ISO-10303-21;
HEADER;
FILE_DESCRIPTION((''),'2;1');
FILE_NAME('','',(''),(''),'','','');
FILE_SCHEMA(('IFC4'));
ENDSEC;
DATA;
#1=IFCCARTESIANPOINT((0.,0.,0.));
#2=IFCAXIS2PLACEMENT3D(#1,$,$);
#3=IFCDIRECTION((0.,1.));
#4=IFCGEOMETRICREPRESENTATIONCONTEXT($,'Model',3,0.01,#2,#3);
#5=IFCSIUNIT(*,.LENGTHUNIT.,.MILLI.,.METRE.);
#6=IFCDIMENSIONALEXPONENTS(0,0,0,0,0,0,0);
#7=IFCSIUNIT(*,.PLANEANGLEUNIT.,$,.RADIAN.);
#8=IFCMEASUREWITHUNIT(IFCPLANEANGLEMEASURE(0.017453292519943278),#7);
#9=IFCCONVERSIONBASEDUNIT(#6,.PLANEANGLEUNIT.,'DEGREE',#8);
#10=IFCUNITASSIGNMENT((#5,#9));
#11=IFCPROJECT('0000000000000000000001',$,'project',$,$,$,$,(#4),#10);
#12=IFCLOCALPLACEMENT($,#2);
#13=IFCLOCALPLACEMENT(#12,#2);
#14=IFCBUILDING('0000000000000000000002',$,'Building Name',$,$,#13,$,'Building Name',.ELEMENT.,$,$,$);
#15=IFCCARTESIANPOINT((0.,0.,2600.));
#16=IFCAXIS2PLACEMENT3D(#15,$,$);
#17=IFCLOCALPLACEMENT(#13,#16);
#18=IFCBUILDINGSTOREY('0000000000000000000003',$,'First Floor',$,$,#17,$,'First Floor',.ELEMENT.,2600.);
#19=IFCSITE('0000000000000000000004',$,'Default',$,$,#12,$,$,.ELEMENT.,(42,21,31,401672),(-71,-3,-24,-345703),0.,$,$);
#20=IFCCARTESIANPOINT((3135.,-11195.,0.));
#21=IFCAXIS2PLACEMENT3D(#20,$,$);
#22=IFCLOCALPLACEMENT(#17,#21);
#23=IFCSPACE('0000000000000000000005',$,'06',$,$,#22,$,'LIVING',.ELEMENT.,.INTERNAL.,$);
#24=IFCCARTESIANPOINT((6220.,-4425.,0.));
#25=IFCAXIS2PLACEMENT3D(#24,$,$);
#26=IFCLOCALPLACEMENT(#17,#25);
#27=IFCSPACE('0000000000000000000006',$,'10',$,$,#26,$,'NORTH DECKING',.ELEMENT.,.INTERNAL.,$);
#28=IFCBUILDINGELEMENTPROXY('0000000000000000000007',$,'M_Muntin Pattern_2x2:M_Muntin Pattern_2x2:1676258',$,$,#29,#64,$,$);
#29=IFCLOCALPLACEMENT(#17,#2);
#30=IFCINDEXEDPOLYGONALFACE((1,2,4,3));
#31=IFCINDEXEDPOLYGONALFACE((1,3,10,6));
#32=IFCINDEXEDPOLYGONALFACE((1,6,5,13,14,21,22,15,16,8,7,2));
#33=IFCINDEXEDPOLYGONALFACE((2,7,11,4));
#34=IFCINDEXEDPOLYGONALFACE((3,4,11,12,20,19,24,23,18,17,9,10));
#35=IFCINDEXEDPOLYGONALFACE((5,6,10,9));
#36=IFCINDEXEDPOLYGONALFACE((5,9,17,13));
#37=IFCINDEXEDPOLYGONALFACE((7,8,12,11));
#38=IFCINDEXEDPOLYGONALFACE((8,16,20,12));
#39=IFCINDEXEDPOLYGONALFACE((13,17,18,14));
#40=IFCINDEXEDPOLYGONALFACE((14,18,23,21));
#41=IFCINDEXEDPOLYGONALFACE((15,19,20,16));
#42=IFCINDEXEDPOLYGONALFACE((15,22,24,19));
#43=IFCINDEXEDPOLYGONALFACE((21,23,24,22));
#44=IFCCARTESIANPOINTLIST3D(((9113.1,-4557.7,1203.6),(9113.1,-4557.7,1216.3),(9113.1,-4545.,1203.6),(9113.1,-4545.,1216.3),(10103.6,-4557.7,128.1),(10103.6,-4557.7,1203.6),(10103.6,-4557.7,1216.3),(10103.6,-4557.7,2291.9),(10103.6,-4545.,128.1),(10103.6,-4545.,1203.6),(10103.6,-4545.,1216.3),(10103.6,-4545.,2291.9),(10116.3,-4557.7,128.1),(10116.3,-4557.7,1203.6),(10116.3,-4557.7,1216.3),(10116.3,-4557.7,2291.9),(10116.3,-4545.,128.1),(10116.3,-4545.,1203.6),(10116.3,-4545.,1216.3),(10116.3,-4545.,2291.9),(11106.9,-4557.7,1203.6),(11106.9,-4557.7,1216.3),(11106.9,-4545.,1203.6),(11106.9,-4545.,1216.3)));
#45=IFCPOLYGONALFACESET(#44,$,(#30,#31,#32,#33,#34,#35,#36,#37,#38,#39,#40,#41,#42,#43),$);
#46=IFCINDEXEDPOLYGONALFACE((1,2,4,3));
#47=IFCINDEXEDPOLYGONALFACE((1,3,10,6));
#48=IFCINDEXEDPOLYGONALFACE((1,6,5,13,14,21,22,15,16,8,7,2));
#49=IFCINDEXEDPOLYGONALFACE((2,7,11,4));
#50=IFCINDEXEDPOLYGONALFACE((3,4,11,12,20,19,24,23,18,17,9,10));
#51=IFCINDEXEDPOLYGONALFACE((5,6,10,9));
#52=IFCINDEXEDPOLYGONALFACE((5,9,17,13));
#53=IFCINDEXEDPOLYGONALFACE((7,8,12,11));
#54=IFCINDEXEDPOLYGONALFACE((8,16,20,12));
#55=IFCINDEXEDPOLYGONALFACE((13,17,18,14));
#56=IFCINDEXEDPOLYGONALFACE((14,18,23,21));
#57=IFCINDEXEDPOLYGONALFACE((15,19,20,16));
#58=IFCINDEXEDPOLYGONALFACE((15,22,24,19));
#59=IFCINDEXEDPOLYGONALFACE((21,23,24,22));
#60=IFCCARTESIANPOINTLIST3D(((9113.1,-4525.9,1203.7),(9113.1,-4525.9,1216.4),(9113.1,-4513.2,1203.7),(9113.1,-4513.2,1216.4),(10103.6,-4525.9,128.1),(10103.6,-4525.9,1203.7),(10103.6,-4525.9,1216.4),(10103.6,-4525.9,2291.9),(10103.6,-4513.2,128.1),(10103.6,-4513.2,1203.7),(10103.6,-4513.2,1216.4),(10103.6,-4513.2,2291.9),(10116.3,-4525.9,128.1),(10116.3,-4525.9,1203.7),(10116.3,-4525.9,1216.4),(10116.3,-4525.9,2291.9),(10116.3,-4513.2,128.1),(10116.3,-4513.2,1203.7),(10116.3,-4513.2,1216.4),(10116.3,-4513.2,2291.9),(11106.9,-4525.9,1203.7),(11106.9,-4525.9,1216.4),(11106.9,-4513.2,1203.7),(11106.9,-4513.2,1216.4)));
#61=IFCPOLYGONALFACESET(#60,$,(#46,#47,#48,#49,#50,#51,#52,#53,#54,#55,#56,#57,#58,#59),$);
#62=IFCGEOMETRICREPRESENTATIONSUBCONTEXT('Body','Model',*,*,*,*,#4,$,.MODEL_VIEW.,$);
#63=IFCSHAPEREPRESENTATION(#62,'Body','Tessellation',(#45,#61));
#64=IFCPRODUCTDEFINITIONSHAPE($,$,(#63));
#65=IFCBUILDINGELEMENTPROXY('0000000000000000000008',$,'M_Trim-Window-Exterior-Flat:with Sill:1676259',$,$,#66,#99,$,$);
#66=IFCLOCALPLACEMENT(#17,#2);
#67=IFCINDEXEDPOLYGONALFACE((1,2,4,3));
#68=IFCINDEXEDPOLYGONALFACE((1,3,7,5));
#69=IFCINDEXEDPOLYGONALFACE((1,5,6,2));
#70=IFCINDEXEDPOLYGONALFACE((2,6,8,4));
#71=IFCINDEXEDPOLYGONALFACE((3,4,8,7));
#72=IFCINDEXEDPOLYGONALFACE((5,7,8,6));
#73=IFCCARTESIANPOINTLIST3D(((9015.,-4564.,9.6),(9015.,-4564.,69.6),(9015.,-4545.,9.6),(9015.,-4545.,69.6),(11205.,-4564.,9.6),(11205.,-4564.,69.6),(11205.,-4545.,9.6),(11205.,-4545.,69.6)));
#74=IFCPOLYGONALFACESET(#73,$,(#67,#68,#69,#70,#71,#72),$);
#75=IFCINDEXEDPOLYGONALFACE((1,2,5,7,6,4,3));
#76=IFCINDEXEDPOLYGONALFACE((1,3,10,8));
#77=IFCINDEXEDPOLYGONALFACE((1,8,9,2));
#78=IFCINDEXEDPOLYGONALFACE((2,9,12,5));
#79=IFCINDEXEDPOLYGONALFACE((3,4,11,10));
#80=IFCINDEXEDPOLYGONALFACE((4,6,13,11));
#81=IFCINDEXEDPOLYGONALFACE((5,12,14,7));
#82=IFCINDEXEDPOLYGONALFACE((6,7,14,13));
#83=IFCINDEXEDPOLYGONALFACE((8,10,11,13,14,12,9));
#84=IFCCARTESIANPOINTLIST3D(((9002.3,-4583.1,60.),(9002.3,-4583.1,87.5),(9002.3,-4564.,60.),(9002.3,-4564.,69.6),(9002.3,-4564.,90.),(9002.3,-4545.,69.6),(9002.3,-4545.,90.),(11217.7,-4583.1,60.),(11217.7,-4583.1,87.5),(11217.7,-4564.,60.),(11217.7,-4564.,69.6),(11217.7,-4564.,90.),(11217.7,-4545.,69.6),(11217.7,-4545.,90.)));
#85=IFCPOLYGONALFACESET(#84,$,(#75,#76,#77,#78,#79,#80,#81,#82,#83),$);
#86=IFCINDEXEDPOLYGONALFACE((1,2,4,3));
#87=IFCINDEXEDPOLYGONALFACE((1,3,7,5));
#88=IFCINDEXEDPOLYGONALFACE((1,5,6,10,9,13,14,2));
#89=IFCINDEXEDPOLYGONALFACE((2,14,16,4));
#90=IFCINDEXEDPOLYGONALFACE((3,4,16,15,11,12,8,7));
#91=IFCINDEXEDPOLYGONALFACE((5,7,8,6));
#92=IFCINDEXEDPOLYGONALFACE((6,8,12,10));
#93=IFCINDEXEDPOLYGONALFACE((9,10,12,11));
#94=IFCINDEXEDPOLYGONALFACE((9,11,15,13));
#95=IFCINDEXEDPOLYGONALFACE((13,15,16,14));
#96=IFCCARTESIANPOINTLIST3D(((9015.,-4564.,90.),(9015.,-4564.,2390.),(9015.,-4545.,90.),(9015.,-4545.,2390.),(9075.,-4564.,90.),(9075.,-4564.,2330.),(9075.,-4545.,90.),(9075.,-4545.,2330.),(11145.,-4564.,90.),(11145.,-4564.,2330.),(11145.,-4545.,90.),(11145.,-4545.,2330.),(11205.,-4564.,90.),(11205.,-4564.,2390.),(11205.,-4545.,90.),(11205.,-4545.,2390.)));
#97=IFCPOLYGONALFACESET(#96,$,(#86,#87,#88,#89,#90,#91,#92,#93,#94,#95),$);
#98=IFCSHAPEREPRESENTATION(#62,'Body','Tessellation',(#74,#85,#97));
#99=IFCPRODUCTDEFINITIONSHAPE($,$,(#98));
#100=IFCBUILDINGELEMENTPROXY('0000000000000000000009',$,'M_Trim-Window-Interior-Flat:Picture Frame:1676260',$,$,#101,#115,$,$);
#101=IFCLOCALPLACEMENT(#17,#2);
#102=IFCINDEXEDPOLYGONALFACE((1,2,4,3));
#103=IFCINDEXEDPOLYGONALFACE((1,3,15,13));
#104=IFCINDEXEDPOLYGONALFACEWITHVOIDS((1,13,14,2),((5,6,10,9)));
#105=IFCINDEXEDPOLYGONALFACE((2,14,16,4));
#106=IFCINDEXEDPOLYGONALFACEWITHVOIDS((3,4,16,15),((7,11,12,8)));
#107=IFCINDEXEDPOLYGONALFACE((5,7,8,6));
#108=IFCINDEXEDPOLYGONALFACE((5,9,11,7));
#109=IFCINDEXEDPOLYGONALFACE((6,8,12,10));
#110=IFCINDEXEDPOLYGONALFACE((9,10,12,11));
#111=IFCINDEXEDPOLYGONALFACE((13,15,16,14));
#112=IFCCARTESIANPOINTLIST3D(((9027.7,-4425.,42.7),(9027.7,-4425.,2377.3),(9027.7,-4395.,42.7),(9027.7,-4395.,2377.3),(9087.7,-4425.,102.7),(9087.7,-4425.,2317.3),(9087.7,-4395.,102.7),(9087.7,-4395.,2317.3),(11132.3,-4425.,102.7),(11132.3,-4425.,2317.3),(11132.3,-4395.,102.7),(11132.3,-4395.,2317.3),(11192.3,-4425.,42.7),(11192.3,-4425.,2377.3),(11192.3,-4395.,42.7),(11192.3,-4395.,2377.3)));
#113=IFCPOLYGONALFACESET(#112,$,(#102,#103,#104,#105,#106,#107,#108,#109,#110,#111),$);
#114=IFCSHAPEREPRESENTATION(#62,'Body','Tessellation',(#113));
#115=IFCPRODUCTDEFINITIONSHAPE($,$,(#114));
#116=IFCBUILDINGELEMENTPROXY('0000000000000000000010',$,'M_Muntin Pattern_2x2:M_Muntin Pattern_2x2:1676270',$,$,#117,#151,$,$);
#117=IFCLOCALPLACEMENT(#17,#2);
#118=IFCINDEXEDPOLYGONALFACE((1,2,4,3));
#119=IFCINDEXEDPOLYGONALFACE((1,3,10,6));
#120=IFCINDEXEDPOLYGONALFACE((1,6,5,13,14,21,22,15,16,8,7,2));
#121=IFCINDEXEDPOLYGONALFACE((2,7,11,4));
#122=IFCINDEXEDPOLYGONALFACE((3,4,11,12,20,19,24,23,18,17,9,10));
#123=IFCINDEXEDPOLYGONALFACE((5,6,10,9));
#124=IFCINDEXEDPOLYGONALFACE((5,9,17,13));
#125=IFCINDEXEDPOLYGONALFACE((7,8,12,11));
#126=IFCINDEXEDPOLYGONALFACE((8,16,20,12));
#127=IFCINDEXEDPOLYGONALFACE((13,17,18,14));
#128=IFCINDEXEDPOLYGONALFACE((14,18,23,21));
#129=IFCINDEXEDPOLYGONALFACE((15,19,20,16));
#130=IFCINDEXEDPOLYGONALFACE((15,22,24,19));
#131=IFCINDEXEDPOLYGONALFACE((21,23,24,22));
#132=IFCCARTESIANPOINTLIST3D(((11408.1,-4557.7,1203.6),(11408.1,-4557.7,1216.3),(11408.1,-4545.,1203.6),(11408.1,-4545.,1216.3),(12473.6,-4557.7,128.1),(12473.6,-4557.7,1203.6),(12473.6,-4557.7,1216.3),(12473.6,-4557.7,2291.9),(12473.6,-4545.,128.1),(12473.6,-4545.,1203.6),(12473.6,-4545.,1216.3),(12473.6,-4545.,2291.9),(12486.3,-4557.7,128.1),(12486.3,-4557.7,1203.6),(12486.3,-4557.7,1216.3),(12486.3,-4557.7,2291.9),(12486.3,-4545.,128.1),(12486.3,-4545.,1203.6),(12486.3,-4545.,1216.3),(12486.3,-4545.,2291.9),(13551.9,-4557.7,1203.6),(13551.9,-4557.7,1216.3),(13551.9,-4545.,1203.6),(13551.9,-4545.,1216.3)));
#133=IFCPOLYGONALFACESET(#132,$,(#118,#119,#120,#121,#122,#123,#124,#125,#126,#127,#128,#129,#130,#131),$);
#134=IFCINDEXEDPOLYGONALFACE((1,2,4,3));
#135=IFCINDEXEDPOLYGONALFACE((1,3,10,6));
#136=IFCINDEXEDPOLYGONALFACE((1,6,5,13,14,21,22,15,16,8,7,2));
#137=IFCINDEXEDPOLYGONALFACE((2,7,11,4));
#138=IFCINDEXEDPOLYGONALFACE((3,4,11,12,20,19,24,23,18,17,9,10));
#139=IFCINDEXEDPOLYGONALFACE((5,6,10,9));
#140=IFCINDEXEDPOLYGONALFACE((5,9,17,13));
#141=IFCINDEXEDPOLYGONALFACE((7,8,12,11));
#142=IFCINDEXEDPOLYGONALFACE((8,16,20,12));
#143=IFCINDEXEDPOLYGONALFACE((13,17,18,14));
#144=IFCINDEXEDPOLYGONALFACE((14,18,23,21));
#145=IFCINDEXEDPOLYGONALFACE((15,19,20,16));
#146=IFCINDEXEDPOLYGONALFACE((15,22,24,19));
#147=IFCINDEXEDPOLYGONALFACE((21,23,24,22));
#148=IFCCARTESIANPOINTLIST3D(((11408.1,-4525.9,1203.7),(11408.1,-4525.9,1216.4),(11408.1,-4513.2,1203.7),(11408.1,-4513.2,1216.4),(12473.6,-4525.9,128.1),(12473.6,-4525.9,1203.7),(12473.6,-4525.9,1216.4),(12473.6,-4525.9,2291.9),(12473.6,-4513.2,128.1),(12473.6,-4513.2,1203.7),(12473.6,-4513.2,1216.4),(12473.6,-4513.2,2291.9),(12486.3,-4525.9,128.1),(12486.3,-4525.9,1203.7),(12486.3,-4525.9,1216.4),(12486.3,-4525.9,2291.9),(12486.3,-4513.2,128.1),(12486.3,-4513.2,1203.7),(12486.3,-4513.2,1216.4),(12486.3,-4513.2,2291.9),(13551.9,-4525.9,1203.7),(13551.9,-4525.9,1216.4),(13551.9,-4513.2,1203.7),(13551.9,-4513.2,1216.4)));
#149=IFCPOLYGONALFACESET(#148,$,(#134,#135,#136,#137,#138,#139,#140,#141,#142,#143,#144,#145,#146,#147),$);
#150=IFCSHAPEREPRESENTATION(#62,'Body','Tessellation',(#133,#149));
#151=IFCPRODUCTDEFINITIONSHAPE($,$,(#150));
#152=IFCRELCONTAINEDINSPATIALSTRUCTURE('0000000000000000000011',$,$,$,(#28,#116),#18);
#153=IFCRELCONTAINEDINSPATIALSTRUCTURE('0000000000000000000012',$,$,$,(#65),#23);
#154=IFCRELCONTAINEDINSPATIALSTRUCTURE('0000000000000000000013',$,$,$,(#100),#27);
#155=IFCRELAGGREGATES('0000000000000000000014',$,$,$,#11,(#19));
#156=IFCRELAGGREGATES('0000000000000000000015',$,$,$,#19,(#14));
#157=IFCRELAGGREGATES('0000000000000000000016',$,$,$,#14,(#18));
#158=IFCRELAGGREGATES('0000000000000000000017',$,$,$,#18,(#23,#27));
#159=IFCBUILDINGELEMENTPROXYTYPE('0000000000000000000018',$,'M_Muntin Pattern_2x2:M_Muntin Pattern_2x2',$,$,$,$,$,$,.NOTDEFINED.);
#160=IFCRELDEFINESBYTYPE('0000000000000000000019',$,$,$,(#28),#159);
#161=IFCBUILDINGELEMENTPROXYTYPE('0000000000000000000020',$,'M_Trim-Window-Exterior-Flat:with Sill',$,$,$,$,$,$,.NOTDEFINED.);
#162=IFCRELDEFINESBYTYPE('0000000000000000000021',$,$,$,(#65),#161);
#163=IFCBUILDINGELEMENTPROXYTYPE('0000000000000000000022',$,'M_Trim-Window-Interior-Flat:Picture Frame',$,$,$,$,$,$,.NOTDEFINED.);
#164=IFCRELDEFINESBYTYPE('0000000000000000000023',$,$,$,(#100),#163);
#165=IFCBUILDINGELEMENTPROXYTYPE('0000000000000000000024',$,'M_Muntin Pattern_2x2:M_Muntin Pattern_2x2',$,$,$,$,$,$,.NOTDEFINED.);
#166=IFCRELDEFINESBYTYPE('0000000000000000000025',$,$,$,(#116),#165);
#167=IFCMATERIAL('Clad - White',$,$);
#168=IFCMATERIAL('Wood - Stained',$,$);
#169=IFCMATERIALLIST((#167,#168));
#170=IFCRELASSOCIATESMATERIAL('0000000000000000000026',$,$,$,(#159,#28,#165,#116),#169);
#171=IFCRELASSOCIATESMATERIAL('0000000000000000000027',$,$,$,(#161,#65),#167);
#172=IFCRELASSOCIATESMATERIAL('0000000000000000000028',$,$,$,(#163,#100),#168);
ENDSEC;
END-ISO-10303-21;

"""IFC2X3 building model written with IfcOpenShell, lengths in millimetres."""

from ifc_helpers import new_model, entity, si_unit, converted_unit, direction, frame, frame_2d, origin, place, context, subcontext, project, spatial, polyline, rectangle, outline, extrude, source, transform, mapped, material, material_list, type_object, type_shapes, element, save


model = new_model("IFC2X3")

# Units and contexts
model_context = context("Model", 3, precision=0.01, world=origin(), true_north=direction((0.0, 1.0)))
body_context = subcontext(model_context, "Body", "Model", "MODEL_VIEW")
ifc_project = project(units=[si_unit("LENGTHUNIT", "METRE", prefix="MILLI"), converted_unit("PLANEANGLEUNIT", "DEGREE", entity("IfcPlaneAngleMeasure", 0.017453292519943278), si_unit("PLANEANGLEUNIT", "RADIAN"), dimensions=[0, 0, 0, 0, 0, 0, 0])], contexts=[model_context])

# Site, building, storey
site_placement = place(None, origin())
site = spatial("IfcSite", under=ifc_project, at=site_placement, Name="Default", CompositionType="ELEMENT", RefLatitude=(42, 21, 31, 401672), RefLongitude=(-71, -3, -24, -345703), RefElevation=0.0)
building_placement = place(site_placement, origin())
building = spatial("IfcBuilding", under=site, at=building_placement, Name="Building Name", LongName="Building Name", CompositionType="ELEMENT")
storey_placement = place(building_placement, frame((0.0, 0.0, 2600.0)))
storey = spatial("IfcBuildingStorey", under=building, at=storey_placement, Name="First Floor", LongName="First Floor", CompositionType="ELEMENT", Elevation=2600.0)

# Shared definitions
space_1_placement = place(storey_placement, frame((3135.0, -11195.0, 0.0)))
space_1 = spatial("IfcSpace", under=storey, at=space_1_placement, Name="06", LongName="LIVING", CompositionType="ELEMENT", InteriorOrExteriorSpace="INTERNAL")

# Building element proxies
ifc_material_1 = material(Name="Clad - White")
ifc_material_2 = material(Name="Wood - Stained")
ifc_material_list_1 = material_list([ifc_material_1, ifc_material_2])
building_element_proxy_type_1 = type_object("IfcBuildingElementProxyType", Name="M_Muntin Pattern_2x2:M_Muntin Pattern_2x2", PredefinedType="NOTDEFINED", material=ifc_material_list_1)
shared_shape_1 = source(origin(), body_context, "Body", "SweptSolid", [
    extrude(outline(polyline([(6.4, -6.4), (1081.9, -6.4), (1081.9, 6.3), (6.4, 6.3), (6.4, 996.9), (-6.3, 996.9), (-6.3, 6.3), (-1081.9, 6.3), (-1081.9, -6.4), (-6.3, -6.4), (-6.3, -996.9), (6.4, -996.9), (6.4, -6.4)])), frame((0.0, -22.2, 1081.9), z_axis=(0.0, 1.0, 0.0), x_axis=(0.0, 0.0, 1.0)), (0.0, 0.0, 1.0), 12.7),
    extrude(outline(polyline([(6.4, -6.4), (1081.9, -6.4), (1081.9, 6.3), (6.4, 6.3), (6.4, 996.9), (-6.3, 996.9), (-6.3, 6.3), (-1081.9, 6.3), (-1081.9, -6.4), (-6.3, -6.4), (-6.3, -996.9), (6.4, -996.9), (6.4, -6.4)])), frame((0.0, 9.5, 1081.9), z_axis=(0.0, 1.0, 0.0), x_axis=(0.0, 0.0, 1.0)), (0.0, 0.0, 1.0), 12.7),
])
type_shapes(building_element_proxy_type_1, [shared_shape_1])
proxy_1_placement = place(storey_placement, frame((10110.0, -4535.5, 128.1)))
element("IfcBuildingElementProxy", 1, at=proxy_1_placement, inside=storey, type_object=building_element_proxy_type_1, material=ifc_material_list_1, Name="M_Muntin Pattern_2x2:M_Muntin Pattern_2x2:1676258", context=body_context, shape_type="MappedRepresentation", body=[
    mapped(shared_shape_1, transform((0.0, 0.0, 0.0), scale=1.0)),
])
building_element_proxy_type_2 = type_object("IfcBuildingElementProxyType", Name="M_Trim-Window-Exterior-Flat:with Sill", PredefinedType="NOTDEFINED", material=ifc_material_1)
shared_shape_2 = source(origin(), body_context, "Body", "SweptSolid", [
    extrude(rectangle(XDim=2190.0, YDim=60.0, at=frame_2d((0.0, 0.0), x_axis=(1.0, 0.0))), frame((0.0, -2290.4, 0.0), z_axis=(0.0, 0.0, 1.0), x_axis=(-1.0, 0.0, 0.0)), (0.0, 0.0, 1.0), 19.0),
    extrude(outline(polyline([(-19.0, -15.2), (0.0, -15.2), (0.0, -5.7), (19.0, -5.7), (19.0, 14.8), (0.0, 14.8), (-19.0, 12.3), (-19.0, -15.2)])), frame((-1107.7, -2254.8, 19.0), z_axis=(1.0, 0.0, 0.0), x_axis=(0.0, 0.0, -1.0)), (0.0, 0.0, 1.0), 2215.4),
    extrude(outline(polyline([(-1165.0, -1095.0), (1135.0, -1095.0), (1135.0, -1035.0), (-1105.0, -1035.0), (-1105.0, 1035.0), (1135.0, 1035.0), (1135.0, 1095.0), (-1165.0, 1095.0), (-1165.0, -1095.0)])), frame((0.0, -1105.0, 0.0), z_axis=(0.0, 0.0, 1.0), x_axis=(0.0, -1.0, 0.0)), (0.0, 0.0, 1.0), 19.0),
])
type_shapes(building_element_proxy_type_2, [shared_shape_2])
proxy_2_placement = place(space_1_placement, frame((6975.0, 6650.0, 2330.0), z_axis=(0.0, -1.0, 0.0), x_axis=(1.0, 0.0, 0.0)))
element("IfcBuildingElementProxy", 2, at=proxy_2_placement, inside=space_1, type_object=building_element_proxy_type_2, material=ifc_material_1, Name="M_Trim-Window-Exterior-Flat:with Sill:1676259", context=body_context, shape_type="MappedRepresentation", body=[
    mapped(shared_shape_2, transform((0.0, 0.0, 0.0), scale=1.0)),
])

# Shared definitions
space_2_placement = place(storey_placement, frame((6220.0, -4425.0, 0.0)))
space_2 = spatial("IfcSpace", under=storey, at=space_2_placement, Name="10", LongName="NORTH DECKING", CompositionType="ELEMENT", InteriorOrExteriorSpace="INTERNAL")

# Building element proxies
building_element_proxy_type_3 = type_object("IfcBuildingElementProxyType", Name="M_Trim-Window-Interior-Flat:Picture Frame", PredefinedType="NOTDEFINED", material=ifc_material_2)
shared_shape_3 = source(origin(), body_context, "Body", "SweptSolid", [
    extrude(outline(polyline([(-1082.3, -1167.3), (1082.3, -1167.3), (1082.3, 1167.3), (-1082.3, 1167.3), (-1082.3, -1167.3)]), holes=[polyline([(-1022.3, -1107.3), (-1022.3, 1107.3), (1022.3, 1107.3), (1022.3, -1107.3), (-1022.3, -1107.3)])]), frame((0.0, -1120.0, 0.0), z_axis=(0.0, 0.0, 1.0), x_axis=(-1.0, 0.0, 0.0)), (0.0, 0.0, 1.0), 30.0),
])
type_shapes(building_element_proxy_type_3, [shared_shape_3])
proxy_3_placement = place(space_2_placement, frame((3890.0, 0.0, 2330.0), z_axis=(0.0, 1.0, 0.0), x_axis=(-1.0, 0.0, 0.0)))
element("IfcBuildingElementProxy", 3, at=proxy_3_placement, inside=space_2, type_object=building_element_proxy_type_3, material=ifc_material_2, Name="M_Trim-Window-Interior-Flat:Picture Frame:1676260", context=body_context, shape_type="MappedRepresentation", body=[
    mapped(shared_shape_3, transform((0.0, 0.0, 0.0), scale=1.0)),
])
building_element_proxy_type_4 = type_object("IfcBuildingElementProxyType", Name="M_Muntin Pattern_2x2:M_Muntin Pattern_2x2", PredefinedType="NOTDEFINED", material=ifc_material_list_1)
shared_shape_4 = source(origin(), body_context, "Body", "SweptSolid", [
    extrude(outline(polyline([(6.4, -6.4), (1081.9, -6.4), (1081.9, 6.3), (6.4, 6.3), (6.4, 1071.9), (-6.3, 1071.9), (-6.3, 6.3), (-1081.9, 6.3), (-1081.9, -6.4), (-6.3, -6.4), (-6.3, -1071.9), (6.4, -1071.9), (6.4, -6.4)])), frame((0.0, -22.2, 1081.9), z_axis=(0.0, 1.0, 0.0), x_axis=(0.0, 0.0, 1.0)), (0.0, 0.0, 1.0), 12.7),
    extrude(outline(polyline([(6.4, -6.4), (1081.9, -6.4), (1081.9, 6.3), (6.4, 6.3), (6.4, 1071.9), (-6.3, 1071.9), (-6.3, 6.3), (-1081.9, 6.3), (-1081.9, -6.4), (-6.3, -6.4), (-6.3, -1071.9), (6.4, -1071.9), (6.4, -6.4)])), frame((0.0, 9.5, 1081.9), z_axis=(0.0, 1.0, 0.0), x_axis=(0.0, 0.0, 1.0)), (0.0, 0.0, 1.0), 12.7),
])
type_shapes(building_element_proxy_type_4, [shared_shape_4])
proxy_4_placement = place(storey_placement, frame((12480.0, -4535.5, 128.1)))
element("IfcBuildingElementProxy", 4, at=proxy_4_placement, inside=storey, type_object=building_element_proxy_type_4, material=ifc_material_list_1, Name="M_Muntin Pattern_2x2:M_Muntin Pattern_2x2:1676270", context=body_context, shape_type="MappedRepresentation", body=[
    mapped(shared_shape_4, transform((0.0, 0.0, 0.0), scale=1.0)),
])

save(model, "model.ifc")
